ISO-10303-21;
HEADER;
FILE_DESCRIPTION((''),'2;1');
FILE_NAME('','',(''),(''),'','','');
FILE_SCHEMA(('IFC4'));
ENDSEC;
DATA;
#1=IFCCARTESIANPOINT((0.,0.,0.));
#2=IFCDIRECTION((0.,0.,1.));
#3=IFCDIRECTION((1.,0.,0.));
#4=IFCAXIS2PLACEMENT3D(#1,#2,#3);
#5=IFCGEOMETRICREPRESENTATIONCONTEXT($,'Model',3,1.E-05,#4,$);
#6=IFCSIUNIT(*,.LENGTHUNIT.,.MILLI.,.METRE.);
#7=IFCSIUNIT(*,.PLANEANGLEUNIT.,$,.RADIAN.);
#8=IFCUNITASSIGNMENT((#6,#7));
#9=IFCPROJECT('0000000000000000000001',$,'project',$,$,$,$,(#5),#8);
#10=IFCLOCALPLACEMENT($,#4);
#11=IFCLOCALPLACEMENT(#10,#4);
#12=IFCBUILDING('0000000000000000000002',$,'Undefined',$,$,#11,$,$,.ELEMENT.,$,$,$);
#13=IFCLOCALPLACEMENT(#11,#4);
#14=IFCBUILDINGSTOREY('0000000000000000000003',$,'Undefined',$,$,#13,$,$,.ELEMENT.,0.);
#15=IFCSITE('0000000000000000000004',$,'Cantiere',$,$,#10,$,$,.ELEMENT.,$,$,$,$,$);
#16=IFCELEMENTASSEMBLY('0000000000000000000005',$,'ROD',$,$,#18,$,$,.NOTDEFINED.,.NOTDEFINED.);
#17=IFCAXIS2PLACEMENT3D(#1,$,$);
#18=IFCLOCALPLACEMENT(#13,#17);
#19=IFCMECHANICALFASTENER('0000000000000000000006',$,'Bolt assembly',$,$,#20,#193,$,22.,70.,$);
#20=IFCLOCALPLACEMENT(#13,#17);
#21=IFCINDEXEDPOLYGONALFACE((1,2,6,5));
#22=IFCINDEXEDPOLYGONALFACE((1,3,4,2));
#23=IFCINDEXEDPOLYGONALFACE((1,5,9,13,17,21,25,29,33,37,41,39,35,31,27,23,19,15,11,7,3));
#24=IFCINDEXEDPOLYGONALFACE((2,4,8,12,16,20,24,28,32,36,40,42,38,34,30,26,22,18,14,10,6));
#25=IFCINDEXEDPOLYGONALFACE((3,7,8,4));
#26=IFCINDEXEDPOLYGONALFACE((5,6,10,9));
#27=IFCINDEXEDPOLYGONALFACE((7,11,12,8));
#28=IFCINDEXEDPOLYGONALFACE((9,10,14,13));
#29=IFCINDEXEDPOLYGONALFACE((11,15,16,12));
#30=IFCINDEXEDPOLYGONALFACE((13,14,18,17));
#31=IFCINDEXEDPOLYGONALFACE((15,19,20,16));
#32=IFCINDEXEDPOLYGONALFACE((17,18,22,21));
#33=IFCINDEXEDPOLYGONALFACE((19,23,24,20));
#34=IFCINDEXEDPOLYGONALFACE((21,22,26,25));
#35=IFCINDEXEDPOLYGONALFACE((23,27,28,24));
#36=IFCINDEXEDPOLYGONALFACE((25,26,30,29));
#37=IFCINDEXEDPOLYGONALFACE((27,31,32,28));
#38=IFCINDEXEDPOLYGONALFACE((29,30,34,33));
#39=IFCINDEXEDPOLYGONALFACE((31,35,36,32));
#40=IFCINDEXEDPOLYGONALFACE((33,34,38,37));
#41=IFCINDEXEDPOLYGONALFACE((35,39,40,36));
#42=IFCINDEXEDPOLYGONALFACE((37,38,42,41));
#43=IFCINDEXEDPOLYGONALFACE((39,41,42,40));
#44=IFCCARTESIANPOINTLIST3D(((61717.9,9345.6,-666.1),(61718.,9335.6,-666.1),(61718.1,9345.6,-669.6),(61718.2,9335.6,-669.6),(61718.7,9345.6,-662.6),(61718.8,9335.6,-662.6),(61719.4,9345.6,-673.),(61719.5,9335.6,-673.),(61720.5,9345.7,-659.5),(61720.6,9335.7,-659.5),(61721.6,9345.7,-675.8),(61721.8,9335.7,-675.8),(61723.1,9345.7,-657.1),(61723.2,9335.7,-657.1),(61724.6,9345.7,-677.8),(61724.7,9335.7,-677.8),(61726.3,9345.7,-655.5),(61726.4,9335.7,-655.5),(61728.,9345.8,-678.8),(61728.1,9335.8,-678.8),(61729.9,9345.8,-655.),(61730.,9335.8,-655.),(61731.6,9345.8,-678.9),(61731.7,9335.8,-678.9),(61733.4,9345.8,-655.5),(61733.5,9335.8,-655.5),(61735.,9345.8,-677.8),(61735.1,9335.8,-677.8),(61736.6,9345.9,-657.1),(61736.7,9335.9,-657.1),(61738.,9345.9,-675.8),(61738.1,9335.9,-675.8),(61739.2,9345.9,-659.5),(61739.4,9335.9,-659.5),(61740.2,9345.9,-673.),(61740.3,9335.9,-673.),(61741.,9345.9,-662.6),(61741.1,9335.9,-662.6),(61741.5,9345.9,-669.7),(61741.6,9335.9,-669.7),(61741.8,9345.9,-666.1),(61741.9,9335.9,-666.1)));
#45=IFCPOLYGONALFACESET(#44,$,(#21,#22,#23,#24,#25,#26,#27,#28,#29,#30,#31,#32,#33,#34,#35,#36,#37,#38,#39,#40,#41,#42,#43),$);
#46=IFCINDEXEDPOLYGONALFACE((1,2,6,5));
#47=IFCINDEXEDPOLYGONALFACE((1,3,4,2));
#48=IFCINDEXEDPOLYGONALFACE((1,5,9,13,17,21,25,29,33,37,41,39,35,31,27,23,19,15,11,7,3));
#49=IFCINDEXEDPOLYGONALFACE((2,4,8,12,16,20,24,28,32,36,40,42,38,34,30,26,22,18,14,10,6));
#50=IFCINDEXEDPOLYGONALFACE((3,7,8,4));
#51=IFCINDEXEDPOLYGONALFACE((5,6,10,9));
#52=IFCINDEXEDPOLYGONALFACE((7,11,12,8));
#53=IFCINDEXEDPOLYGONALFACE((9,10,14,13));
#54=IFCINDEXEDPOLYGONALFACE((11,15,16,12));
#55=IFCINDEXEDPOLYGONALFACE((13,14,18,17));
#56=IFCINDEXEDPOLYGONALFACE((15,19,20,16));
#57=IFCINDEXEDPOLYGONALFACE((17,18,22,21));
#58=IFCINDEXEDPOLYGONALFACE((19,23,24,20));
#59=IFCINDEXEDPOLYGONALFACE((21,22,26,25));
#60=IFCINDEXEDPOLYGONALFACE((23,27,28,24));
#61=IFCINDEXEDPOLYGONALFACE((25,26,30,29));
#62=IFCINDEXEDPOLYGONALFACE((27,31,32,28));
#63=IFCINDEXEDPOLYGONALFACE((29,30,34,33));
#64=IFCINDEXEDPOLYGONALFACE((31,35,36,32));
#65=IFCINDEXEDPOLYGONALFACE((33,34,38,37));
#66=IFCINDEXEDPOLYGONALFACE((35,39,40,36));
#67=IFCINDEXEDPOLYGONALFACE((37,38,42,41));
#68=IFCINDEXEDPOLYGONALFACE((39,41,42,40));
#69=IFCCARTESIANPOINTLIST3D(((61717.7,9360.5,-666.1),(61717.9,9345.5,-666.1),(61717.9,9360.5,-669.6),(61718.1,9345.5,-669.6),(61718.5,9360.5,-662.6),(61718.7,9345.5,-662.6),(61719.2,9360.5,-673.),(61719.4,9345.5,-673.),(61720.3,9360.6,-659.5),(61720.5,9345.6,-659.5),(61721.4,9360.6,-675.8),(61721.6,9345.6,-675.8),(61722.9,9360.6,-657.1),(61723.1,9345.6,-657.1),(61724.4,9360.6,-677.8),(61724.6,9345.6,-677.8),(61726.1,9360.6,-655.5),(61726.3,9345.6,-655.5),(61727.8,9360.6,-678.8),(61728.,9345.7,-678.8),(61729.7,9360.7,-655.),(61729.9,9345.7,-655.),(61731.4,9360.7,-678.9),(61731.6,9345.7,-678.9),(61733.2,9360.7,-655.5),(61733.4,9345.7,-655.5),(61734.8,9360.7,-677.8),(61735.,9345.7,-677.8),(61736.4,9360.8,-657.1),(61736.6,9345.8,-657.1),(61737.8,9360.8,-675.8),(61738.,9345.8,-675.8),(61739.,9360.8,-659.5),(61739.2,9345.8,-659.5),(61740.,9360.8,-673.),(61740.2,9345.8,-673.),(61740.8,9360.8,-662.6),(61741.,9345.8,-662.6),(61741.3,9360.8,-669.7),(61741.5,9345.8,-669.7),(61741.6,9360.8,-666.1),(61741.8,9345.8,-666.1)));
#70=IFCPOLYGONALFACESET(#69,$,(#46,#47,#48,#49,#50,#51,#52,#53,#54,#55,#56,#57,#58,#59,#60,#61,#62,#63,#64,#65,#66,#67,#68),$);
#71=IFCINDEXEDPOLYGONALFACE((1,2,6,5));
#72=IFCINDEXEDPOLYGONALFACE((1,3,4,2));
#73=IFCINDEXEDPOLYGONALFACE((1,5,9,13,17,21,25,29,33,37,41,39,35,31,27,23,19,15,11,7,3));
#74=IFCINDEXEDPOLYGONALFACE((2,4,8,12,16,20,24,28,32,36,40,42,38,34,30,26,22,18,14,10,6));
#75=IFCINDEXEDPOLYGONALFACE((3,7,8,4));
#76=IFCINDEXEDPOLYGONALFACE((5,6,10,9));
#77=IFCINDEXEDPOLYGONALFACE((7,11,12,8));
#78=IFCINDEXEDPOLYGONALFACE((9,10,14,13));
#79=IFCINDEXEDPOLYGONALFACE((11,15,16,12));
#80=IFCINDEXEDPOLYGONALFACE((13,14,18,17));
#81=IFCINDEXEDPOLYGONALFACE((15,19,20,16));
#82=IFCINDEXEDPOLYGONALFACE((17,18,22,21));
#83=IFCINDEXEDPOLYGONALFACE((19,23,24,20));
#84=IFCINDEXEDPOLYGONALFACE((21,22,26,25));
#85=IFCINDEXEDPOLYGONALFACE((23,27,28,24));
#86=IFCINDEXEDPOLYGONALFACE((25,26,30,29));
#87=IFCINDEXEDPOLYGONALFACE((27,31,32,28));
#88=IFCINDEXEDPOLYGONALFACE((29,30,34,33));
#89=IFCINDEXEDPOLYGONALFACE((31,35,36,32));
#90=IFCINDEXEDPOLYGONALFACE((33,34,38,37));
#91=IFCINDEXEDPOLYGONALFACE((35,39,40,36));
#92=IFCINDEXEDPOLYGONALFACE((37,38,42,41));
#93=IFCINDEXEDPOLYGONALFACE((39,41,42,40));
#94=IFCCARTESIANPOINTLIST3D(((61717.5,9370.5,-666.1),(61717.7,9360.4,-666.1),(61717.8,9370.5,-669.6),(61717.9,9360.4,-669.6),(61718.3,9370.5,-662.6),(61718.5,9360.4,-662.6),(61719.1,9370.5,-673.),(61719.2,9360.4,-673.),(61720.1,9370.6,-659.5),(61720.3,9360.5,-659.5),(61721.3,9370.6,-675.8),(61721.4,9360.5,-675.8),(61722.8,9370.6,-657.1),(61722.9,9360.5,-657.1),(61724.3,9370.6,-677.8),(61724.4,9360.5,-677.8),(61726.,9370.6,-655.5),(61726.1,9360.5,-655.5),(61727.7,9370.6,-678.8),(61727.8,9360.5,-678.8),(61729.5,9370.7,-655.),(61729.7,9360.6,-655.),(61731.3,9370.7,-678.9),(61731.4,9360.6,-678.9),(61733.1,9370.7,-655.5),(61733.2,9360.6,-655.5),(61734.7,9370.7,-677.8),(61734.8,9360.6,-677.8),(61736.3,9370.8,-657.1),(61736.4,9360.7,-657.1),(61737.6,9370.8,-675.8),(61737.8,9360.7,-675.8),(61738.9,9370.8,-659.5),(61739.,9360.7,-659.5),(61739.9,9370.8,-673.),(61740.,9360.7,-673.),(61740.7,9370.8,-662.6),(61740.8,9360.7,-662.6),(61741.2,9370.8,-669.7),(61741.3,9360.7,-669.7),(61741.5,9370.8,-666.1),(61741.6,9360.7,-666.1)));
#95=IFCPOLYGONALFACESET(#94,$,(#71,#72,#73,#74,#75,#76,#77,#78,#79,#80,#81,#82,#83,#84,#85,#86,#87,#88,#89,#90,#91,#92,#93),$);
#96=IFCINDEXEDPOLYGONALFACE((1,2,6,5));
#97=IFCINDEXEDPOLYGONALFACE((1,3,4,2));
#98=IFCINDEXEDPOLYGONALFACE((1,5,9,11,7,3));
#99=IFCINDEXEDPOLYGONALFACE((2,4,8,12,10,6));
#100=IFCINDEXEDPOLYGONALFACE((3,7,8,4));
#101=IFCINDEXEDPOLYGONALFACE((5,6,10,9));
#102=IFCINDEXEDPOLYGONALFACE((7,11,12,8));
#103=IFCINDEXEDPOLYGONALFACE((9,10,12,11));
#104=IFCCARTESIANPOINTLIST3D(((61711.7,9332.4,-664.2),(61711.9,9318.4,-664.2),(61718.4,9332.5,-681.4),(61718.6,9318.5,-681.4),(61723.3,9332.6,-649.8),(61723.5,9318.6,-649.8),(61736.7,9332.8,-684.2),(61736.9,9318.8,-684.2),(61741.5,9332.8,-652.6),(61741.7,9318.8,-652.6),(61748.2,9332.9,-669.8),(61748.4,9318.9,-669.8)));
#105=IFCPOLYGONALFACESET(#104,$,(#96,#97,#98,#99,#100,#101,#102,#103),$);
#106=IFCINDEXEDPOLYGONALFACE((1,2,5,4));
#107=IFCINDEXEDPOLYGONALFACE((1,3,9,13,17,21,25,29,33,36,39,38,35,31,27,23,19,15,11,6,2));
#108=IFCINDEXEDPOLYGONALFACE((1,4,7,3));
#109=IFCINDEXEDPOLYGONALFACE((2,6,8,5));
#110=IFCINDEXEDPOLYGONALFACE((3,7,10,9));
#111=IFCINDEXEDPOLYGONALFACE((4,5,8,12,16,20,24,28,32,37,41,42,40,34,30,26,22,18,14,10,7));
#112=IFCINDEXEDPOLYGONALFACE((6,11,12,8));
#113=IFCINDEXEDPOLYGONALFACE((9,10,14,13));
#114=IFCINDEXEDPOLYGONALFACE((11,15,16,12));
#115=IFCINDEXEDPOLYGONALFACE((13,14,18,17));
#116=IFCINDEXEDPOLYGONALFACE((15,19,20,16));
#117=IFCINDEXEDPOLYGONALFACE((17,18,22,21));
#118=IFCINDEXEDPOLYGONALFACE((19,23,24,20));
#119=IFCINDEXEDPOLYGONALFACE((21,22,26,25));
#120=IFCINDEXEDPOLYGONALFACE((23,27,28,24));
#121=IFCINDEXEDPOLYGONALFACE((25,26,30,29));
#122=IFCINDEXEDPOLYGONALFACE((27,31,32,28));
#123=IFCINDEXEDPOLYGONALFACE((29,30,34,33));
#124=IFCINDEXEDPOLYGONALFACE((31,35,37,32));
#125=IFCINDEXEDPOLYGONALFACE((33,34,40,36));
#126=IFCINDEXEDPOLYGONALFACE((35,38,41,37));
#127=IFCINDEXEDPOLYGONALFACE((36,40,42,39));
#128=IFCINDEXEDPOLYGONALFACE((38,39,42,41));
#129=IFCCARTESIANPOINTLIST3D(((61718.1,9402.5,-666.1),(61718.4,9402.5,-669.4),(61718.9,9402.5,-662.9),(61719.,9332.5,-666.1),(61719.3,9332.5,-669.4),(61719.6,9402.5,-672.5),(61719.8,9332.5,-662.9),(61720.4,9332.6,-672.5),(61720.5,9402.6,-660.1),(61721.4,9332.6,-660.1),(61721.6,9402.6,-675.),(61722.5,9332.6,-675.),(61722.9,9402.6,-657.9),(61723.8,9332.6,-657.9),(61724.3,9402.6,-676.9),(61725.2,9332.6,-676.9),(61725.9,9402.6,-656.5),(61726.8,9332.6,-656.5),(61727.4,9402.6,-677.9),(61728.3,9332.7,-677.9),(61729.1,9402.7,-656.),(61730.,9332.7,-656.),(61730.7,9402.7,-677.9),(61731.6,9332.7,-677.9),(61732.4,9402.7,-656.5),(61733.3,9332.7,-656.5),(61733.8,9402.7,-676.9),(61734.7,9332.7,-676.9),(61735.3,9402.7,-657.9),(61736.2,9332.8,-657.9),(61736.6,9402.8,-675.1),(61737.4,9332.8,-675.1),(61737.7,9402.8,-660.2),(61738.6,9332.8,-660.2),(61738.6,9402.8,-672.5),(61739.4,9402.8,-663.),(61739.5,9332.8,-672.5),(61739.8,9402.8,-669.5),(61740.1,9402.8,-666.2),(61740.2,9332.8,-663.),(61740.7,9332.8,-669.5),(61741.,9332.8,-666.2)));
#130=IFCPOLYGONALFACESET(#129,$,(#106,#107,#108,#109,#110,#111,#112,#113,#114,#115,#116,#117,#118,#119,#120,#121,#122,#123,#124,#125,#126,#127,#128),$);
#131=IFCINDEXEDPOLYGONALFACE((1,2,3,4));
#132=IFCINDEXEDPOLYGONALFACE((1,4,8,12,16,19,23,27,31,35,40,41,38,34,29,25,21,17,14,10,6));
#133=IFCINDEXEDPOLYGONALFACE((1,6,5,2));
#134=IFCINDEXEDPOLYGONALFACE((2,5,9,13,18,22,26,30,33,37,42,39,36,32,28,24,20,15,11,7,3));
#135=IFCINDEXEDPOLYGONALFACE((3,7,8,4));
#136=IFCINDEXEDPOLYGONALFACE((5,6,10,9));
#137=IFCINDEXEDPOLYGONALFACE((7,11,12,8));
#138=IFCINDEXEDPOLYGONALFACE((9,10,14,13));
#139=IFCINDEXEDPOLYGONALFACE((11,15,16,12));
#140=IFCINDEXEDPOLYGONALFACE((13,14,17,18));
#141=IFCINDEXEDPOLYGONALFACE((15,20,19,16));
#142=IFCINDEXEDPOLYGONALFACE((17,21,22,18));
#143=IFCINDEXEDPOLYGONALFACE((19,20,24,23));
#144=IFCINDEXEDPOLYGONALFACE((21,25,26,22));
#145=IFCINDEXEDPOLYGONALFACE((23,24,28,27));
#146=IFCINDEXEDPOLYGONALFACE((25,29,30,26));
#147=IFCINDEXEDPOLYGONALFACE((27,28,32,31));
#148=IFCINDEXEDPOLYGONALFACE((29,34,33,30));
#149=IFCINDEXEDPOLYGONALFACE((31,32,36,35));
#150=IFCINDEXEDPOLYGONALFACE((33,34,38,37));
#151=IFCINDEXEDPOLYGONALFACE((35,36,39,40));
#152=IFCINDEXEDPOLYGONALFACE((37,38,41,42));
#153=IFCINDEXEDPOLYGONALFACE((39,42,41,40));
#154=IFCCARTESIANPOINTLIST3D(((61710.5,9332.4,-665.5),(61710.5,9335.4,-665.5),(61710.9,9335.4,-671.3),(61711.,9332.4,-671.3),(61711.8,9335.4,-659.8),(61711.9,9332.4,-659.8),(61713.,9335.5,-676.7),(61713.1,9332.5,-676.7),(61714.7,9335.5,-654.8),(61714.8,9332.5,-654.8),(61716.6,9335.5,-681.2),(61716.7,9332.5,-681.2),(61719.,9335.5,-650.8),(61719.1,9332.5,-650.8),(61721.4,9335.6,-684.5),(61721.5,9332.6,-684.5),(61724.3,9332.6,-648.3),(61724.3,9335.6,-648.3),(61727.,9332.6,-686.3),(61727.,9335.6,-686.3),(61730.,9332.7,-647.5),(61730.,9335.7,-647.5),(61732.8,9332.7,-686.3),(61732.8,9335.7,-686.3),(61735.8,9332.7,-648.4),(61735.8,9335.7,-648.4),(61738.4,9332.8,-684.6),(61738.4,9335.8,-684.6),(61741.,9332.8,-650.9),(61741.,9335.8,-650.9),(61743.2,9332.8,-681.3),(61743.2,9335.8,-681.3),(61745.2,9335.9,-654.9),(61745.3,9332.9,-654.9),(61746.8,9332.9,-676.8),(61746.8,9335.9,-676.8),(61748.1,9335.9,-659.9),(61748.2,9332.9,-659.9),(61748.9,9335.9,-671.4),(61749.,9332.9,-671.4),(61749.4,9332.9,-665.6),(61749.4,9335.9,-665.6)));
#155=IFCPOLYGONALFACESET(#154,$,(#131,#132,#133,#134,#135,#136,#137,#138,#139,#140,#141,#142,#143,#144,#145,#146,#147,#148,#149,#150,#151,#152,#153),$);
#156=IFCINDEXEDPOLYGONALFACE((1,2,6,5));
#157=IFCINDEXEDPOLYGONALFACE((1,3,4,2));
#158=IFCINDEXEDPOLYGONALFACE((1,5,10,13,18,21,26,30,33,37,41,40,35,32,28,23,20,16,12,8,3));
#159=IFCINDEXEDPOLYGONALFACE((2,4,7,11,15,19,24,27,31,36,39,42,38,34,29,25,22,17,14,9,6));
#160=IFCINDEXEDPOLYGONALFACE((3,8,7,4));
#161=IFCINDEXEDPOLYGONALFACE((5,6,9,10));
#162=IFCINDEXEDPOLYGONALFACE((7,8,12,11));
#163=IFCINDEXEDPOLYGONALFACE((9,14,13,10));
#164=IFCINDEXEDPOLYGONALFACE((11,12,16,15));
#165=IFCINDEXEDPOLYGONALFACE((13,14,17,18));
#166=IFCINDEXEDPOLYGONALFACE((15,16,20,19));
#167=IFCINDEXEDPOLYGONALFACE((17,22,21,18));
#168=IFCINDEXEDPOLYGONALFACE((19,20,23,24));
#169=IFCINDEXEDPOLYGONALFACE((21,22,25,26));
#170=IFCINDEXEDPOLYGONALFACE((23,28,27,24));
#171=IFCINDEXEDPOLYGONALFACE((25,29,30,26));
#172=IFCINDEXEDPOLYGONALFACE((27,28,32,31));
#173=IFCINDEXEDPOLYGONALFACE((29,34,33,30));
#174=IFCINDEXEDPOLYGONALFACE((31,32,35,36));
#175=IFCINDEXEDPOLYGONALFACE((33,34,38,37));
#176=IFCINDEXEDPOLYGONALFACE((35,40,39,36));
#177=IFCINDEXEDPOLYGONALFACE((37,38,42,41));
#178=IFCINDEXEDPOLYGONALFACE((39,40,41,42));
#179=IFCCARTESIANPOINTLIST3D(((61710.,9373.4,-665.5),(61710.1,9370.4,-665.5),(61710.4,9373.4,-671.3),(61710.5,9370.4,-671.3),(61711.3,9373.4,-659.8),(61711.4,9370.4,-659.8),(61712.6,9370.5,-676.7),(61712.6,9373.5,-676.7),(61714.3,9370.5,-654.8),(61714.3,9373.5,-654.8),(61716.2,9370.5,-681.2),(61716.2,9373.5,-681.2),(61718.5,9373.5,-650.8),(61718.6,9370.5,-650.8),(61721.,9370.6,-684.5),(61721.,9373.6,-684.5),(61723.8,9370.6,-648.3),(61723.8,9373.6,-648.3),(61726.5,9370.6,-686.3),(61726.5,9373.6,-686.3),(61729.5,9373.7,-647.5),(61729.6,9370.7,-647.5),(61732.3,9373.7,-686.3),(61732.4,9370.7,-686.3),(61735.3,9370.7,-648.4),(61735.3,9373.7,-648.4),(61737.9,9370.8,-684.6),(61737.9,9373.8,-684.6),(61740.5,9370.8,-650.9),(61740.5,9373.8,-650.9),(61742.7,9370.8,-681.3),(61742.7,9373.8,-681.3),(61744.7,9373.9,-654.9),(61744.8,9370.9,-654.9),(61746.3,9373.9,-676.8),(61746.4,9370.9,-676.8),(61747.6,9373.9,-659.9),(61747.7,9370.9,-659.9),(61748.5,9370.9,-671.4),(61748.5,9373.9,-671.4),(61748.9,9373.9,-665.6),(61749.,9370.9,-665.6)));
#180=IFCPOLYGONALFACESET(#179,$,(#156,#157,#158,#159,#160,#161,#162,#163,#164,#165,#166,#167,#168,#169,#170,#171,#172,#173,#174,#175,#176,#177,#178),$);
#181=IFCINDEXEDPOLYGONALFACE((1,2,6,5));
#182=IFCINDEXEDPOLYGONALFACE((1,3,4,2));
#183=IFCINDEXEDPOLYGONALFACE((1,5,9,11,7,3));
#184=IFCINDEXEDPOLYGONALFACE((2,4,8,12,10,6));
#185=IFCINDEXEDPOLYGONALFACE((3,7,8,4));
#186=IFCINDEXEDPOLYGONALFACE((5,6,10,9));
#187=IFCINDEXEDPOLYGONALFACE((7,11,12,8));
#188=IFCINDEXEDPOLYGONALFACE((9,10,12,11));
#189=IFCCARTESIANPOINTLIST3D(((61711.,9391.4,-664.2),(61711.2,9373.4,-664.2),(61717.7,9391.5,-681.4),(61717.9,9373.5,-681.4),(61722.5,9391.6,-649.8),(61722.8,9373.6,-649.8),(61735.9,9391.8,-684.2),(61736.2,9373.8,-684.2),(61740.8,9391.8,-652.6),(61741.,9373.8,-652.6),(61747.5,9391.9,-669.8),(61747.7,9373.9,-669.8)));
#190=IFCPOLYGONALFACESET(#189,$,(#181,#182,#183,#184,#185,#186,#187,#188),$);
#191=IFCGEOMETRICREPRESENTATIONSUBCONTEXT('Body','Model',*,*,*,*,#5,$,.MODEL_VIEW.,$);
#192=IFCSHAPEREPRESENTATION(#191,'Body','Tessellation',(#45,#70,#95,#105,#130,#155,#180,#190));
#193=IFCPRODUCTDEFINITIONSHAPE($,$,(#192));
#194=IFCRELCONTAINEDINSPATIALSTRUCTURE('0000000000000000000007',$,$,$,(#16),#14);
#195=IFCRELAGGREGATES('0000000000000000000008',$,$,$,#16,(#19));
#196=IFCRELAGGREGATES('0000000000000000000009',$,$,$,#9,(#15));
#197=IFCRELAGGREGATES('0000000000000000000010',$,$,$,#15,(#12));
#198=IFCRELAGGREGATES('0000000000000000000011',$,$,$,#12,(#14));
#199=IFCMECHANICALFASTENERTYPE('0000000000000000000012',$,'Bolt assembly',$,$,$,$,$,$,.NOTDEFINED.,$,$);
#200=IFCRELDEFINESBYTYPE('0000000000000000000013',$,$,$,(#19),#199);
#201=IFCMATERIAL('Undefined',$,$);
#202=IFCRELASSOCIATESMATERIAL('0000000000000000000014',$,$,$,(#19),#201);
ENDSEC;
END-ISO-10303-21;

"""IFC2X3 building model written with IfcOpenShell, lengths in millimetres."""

from ifc_helpers import new_model, si_unit, frame, origin_with_axes, origin_2d_with_axis, place, context, subcontext, project, spatial, polyline, circle, outline, extrude, source, transform, mapped, material, type_object, element, aggregate, save


model = new_model("IFC2X3")

# Units and contexts
model_context = context("Model", 3, precision=1e-05, world=origin_with_axes())
body_context = subcontext(model_context, "Body", "Model", "MODEL_VIEW")
ifc_project = project(units=[si_unit("LENGTHUNIT", "METRE", prefix="MILLI"), si_unit("PLANEANGLEUNIT", "RADIAN")], contexts=[model_context])

# Site, building, storey
site_placement = place(None, origin_with_axes())
site = spatial("IfcSite", under=ifc_project, at=site_placement, Name="Cantiere", CompositionType="ELEMENT")
building_placement = place(site_placement, origin_with_axes())
building = spatial("IfcBuilding", under=site, at=building_placement, Name="Undefined", CompositionType="ELEMENT")
storey_placement = place(building_placement, origin_with_axes())
storey = spatial("IfcBuildingStorey", under=building, at=storey_placement, Name="Undefined", CompositionType="ELEMENT", Elevation=0.0)

# Element assembly, mechanical fastener
ifc_material_1 = material(Name="Undefined")
mechanical_fastener_type = type_object("IfcMechanicalFastenerType", Name="Bolt assembly")
shared_shape_1 = source(origin_with_axes(), body_context, "Body", "SweptSolid", [
    extrude(circle(Radius=12.0, at=origin_2d_with_axis()), frame((0.0, 0.1, 0.0), z_axis=(0.0, 1.0, 0.0), x_axis=(1.0, 0.0, 0.0)), (0.0, 0.0, 1.0), 10.0),
    extrude(circle(Radius=12.0, at=origin_2d_with_axis()), frame((0.0, 10.0, 0.0), z_axis=(0.0, 1.0, 0.0), x_axis=(1.0, 0.0, 0.0)), (0.0, 0.0, 1.0), 15.0),
    extrude(circle(Radius=12.0, at=origin_2d_with_axis()), frame((0.0, 24.9, 0.0), z_axis=(0.0, 1.0, 0.0), x_axis=(1.0, 0.0, 0.0)), (0.0, 0.0, 1.0), 10.1),
    extrude(outline(polyline([(16.0, -9.2), (16.0, 9.2), (0.0, 18.5), (-16.0, 9.2), (-16.0, -9.2), (0.0, -18.5), (16.0, -9.2)])), frame((0.0, -17.0, 0.0), z_axis=(0.0, 1.0, 0.0), x_axis=(1.0, 0.0, 0.0)), (0.0, 0.0, 1.0), 14.0),
    extrude(circle(Radius=11.0, at=origin_2d_with_axis()), frame((0.0, -3.0, 0.0), z_axis=(0.0, 1.0, 0.0), x_axis=(1.0, 0.0, 0.0)), (0.0, 0.0, 1.0), 70.0),
    extrude(circle(Radius=19.5, at=origin_2d_with_axis()), frame((0.0, -3.0, 0.0), z_axis=(0.0, 1.0, 0.0), x_axis=(1.0, 0.0, 0.0)), (0.0, 0.0, 1.0), 3.0),
    extrude(circle(Radius=19.5, at=origin_2d_with_axis()), frame((0.0, 35.0, 0.0), z_axis=(0.0, 1.0, 0.0), x_axis=(1.0, 0.0, 0.0)), (0.0, 0.0, 1.0), 3.0),
    extrude(outline(polyline([(16.0, -9.2), (16.0, 9.2), (0.0, 18.5), (-16.0, 9.2), (-16.0, -9.2), (0.0, -18.5), (16.0, -9.2)])), frame((0.0, 38.0, 0.0), z_axis=(0.0, 1.0, 0.0), x_axis=(1.0, 0.0, 0.0)), (0.0, 0.0, 1.0), 18.0),
])
assembly_1_placement = place(storey_placement, origin_with_axes())
assembly_1 = element("IfcElementAssembly", 1, at=assembly_1_placement, inside=storey, Name="ROD", AssemblyPlace="NOTDEFINED", PredefinedType="NOTDEFINED")
mechanical_fastener_1_placement = place(assembly_1_placement, frame((61729.9, 9335.7, -667.0), z_axis=(-0.362433, -0.004573, 0.931999), x_axis=(0.931925, 0.011759, 0.362462)))
mechanical_fastener_1 = element("IfcMechanicalFastener", 2, at=mechanical_fastener_1_placement, type_object=mechanical_fastener_type, material=ifc_material_1, Name="Bolt assembly", NominalDiameter=22.0, NominalLength=70.0, context=body_context, shape_type="MappedRepresentation", body=[
    mapped(shared_shape_1, transform((0.0, 0.0, 0.0))),
])
aggregate(assembly_1, [mechanical_fastener_1])

save(model, "model.ifc")
